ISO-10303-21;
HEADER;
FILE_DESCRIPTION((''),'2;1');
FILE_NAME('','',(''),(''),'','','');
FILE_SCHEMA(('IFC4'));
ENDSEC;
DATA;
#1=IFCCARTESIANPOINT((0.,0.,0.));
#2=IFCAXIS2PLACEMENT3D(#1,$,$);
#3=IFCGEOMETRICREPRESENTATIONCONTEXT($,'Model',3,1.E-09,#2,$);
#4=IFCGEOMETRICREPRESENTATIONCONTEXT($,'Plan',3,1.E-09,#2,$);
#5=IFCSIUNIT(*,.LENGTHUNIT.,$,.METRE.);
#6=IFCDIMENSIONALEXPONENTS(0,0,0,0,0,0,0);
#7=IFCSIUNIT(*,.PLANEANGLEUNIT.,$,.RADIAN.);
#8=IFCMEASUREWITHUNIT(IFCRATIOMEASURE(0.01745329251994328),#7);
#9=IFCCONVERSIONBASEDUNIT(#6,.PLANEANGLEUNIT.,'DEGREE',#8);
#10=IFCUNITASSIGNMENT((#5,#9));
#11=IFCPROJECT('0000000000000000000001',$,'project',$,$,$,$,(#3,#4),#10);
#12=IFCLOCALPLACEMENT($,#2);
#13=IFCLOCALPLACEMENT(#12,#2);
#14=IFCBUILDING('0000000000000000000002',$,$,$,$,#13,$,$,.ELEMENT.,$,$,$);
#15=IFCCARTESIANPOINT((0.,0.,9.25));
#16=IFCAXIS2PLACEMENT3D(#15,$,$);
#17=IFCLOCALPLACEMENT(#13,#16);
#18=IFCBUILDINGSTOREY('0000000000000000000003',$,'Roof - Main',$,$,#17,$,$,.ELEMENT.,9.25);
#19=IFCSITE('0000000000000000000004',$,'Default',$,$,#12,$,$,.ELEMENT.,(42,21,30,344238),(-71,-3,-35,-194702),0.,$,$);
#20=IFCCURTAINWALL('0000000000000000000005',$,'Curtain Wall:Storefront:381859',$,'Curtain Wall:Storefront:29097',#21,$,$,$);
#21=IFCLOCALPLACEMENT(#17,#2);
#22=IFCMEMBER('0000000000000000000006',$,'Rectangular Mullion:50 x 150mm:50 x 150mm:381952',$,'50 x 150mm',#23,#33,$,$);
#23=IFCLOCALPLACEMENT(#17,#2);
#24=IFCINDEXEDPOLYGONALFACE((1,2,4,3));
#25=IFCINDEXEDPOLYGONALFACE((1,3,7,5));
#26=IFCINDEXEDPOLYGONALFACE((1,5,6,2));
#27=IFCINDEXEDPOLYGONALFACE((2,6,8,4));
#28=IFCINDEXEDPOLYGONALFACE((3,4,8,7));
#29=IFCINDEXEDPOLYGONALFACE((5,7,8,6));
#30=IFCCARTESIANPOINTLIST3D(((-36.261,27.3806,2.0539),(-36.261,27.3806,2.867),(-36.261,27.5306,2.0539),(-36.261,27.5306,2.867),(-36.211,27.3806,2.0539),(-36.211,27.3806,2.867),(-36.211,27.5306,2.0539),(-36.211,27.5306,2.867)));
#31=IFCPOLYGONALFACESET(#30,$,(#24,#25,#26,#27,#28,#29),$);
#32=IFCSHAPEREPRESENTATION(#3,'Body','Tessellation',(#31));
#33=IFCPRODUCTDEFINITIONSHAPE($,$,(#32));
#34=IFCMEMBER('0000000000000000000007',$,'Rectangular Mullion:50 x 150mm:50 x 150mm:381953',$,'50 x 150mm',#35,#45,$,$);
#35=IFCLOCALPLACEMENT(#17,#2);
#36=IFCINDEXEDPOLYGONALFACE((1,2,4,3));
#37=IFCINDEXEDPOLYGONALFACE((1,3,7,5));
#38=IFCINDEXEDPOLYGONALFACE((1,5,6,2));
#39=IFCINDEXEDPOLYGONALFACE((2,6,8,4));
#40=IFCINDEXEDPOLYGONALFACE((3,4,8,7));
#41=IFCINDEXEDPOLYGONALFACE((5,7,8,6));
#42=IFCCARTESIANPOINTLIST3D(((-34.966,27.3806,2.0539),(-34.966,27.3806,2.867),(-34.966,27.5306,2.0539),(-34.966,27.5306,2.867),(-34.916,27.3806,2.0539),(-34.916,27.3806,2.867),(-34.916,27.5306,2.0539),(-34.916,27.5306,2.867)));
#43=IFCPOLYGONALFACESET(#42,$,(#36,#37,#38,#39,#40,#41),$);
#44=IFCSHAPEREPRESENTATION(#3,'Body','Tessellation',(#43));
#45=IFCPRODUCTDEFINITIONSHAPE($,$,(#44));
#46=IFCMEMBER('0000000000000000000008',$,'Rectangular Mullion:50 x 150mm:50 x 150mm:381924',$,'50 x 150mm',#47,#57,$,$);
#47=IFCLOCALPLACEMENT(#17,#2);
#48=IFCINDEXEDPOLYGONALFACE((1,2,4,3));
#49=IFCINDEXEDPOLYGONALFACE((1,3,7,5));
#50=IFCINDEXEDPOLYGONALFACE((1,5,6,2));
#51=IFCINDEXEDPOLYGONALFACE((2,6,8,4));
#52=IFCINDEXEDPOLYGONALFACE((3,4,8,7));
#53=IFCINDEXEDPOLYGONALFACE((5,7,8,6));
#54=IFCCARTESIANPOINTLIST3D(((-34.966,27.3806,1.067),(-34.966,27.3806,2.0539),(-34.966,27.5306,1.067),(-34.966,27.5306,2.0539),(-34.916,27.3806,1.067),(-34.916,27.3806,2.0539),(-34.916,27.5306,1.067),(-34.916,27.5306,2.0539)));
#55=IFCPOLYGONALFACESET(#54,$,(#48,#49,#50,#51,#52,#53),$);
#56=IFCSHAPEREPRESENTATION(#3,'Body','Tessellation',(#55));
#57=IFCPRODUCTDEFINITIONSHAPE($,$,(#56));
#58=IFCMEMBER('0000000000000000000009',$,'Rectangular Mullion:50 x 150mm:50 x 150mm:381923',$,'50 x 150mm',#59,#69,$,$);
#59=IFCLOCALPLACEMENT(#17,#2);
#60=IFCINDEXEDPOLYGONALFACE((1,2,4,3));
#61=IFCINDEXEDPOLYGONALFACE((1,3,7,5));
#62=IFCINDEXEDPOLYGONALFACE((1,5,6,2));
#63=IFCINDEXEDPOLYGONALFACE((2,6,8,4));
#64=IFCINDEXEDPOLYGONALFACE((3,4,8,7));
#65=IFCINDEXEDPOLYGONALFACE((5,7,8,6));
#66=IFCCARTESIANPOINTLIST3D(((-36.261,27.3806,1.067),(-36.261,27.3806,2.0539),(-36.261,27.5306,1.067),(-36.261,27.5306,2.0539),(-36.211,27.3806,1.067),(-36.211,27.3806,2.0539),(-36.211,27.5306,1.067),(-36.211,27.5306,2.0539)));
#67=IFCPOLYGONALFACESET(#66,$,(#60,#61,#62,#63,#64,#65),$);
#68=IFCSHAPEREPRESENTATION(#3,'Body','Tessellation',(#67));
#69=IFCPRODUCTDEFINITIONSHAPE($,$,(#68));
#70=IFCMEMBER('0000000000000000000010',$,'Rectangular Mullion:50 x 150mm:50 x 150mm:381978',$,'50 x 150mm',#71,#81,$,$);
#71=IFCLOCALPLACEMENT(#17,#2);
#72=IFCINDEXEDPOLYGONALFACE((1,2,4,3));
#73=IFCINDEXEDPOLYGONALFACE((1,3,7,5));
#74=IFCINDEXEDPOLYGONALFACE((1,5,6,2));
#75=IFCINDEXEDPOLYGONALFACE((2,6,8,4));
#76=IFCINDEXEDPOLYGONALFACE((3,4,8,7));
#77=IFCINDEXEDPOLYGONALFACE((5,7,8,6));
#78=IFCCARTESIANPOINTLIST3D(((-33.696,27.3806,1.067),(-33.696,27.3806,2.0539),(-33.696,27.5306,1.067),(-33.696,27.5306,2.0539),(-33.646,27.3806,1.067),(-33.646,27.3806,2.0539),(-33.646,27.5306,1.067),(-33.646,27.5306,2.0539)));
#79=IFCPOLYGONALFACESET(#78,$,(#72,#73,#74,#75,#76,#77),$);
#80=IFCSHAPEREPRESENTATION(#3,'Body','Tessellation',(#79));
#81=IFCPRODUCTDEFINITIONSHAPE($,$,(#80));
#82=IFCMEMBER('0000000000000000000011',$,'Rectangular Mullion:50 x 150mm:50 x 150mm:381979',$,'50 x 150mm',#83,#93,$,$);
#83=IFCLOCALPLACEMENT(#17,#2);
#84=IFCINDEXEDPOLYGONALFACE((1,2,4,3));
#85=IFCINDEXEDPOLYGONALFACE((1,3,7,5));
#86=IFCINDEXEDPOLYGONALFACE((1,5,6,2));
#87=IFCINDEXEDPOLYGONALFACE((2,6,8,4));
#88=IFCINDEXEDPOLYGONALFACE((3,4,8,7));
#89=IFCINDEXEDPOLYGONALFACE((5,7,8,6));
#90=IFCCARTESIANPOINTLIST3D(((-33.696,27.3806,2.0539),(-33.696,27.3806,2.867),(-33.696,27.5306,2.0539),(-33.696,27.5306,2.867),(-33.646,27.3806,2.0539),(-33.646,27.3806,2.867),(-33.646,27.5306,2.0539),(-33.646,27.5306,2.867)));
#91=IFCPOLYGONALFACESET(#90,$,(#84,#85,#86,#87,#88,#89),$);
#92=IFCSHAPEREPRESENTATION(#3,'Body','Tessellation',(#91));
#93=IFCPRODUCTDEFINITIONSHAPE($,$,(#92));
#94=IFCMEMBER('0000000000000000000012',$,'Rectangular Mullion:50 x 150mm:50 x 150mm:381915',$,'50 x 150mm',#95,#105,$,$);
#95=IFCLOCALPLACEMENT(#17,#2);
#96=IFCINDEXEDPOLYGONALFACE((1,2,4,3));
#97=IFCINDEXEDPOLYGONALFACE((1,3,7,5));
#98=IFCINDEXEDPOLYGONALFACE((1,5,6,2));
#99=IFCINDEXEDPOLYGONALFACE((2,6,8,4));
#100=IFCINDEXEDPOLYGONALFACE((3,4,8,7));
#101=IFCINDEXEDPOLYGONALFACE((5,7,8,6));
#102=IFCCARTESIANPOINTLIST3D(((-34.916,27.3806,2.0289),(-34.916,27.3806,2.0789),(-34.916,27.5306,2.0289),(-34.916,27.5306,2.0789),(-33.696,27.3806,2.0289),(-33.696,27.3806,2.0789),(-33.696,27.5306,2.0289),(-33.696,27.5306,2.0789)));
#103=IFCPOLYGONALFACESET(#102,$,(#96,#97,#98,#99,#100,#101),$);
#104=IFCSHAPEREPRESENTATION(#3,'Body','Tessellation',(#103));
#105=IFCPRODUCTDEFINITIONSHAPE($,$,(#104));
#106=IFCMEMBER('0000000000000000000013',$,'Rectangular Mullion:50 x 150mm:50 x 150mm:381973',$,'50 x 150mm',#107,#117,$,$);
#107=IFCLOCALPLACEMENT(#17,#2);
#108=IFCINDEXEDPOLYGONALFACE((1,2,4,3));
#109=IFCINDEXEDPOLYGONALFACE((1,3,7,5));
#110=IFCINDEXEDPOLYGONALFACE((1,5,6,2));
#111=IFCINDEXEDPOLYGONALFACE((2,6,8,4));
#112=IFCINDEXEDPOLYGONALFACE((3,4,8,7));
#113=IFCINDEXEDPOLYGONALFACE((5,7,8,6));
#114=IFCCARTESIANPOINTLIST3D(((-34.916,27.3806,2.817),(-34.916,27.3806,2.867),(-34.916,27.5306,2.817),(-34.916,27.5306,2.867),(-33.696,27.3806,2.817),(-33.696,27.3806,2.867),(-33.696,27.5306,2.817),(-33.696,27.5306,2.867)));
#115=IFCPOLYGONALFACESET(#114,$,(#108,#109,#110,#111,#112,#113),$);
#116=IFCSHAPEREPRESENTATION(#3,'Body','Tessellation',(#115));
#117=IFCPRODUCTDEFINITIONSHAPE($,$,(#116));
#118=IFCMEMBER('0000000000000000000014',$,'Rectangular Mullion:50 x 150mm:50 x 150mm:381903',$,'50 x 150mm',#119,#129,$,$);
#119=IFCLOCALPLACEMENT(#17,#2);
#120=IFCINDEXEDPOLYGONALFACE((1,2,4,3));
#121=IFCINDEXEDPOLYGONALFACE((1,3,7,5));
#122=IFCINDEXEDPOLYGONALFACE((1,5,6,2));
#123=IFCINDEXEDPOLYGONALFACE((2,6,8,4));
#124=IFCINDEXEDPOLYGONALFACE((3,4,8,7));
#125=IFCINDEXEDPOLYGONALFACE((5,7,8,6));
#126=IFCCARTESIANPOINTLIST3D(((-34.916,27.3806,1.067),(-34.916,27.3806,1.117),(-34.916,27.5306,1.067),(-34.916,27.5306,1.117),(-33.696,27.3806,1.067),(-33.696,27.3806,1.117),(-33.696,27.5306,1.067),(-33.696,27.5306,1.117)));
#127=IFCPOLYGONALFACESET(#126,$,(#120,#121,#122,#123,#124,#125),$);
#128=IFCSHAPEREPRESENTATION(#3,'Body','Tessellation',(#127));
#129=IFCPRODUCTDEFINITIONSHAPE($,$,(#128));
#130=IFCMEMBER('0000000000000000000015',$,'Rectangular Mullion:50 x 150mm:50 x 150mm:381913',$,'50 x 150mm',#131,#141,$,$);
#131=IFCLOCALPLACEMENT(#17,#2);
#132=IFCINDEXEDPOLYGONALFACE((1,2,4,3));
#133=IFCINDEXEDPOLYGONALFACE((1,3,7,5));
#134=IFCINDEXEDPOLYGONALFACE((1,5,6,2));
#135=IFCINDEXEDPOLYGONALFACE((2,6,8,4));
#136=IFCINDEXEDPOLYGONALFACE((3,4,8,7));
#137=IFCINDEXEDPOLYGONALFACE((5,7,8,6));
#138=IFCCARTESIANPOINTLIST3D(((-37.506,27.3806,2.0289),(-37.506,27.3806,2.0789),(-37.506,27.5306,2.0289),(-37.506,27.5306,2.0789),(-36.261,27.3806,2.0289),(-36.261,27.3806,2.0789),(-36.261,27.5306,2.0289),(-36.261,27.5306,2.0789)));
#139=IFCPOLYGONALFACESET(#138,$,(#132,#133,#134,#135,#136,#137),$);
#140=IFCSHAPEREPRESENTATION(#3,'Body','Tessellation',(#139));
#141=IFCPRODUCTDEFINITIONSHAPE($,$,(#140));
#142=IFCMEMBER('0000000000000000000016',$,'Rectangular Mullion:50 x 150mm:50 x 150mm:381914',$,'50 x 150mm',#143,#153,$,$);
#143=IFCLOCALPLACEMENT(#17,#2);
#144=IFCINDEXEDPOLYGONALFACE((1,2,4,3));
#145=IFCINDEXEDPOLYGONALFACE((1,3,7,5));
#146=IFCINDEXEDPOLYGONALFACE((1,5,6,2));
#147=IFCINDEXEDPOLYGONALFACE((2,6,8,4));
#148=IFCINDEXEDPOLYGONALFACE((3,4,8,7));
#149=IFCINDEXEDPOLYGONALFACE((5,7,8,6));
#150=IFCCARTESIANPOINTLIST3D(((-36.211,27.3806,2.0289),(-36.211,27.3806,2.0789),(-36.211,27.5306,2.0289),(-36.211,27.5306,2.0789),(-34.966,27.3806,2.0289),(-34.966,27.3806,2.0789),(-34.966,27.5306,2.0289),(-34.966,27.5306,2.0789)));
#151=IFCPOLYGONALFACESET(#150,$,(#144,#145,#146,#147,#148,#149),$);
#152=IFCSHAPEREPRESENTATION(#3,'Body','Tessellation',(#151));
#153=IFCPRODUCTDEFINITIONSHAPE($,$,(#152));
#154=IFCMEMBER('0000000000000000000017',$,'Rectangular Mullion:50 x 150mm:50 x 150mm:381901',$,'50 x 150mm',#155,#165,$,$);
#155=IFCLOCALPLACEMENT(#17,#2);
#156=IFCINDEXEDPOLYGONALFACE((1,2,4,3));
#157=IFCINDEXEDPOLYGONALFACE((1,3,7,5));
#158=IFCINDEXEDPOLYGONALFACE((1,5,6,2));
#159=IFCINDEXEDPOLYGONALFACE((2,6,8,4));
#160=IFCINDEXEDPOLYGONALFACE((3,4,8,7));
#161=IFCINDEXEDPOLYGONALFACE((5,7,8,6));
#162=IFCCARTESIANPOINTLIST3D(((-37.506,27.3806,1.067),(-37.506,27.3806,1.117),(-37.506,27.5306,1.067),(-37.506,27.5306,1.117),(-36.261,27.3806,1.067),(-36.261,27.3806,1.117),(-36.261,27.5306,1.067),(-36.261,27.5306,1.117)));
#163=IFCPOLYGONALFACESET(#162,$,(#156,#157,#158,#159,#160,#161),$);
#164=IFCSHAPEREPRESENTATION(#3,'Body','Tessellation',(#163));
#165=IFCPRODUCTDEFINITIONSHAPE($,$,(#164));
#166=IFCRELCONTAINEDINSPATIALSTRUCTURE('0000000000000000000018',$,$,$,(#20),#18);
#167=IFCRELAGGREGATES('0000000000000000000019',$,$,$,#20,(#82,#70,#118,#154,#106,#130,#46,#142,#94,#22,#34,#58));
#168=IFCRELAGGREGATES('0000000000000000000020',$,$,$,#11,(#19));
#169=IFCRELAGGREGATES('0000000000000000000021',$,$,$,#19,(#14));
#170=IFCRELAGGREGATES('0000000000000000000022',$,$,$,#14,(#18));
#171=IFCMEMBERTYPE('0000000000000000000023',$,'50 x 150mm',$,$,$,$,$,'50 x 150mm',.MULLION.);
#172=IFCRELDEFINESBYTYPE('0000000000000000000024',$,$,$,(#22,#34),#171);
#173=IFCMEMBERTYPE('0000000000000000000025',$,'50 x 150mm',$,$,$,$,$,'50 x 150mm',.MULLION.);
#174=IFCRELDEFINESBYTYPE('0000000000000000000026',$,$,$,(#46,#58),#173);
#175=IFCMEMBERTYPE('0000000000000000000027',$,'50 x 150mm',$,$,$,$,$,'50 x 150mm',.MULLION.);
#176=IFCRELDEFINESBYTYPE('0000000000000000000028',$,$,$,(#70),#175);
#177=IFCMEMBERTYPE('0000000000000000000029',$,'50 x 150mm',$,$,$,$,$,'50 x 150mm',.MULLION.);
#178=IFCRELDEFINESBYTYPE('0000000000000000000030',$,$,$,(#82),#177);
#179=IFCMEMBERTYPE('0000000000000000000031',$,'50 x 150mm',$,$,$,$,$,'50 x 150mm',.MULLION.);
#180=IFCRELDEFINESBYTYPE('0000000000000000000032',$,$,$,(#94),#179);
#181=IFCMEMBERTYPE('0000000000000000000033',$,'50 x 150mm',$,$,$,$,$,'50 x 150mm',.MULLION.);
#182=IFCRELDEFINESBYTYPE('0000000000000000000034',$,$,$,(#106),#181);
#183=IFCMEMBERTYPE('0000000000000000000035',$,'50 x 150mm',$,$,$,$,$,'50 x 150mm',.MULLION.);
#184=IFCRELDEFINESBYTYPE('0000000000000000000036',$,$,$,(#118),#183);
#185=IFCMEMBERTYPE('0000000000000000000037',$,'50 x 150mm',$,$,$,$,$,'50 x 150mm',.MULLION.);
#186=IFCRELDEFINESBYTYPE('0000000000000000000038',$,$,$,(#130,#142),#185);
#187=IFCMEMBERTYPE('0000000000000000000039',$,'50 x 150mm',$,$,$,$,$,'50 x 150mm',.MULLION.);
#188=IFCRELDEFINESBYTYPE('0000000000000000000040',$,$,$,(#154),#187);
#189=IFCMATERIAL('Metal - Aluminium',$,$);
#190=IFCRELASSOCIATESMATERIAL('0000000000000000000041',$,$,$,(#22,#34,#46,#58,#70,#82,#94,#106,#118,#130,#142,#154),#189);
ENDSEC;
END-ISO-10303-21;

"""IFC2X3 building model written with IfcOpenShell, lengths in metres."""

from ifc_helpers import new_model, entity, si_unit, converted_unit, frame, origin, origin_2d_with_axis, place, context, project, spatial, rectangle, extrude, source, transform, mapped, material, type_object, type_shapes, element, aggregate, save


model = new_model("IFC2X3")

# Units and contexts
model_context = context("Model", 3, precision=1e-09, world=origin())
plan_context = context("Plan", 3, precision=1e-09, world=origin())
ifc_project = project(units=[si_unit("LENGTHUNIT", "METRE"), converted_unit("PLANEANGLEUNIT", "DEGREE", entity("IfcRatioMeasure", 0.01745329251994328), si_unit("PLANEANGLEUNIT", "RADIAN"), dimensions=[0, 0, 0, 0, 0, 0, 0])], contexts=[model_context, plan_context])

# Site, building, storey
site_placement = place(None, origin())
site = spatial("IfcSite", under=ifc_project, at=site_placement, Name="Default", CompositionType="ELEMENT", RefLatitude=(42, 21, 30, 344238), RefLongitude=(-71, -3, -35, -194702), RefElevation=0.0)
building_placement = place(site_placement, origin())
building = spatial("IfcBuilding", under=site, at=building_placement, CompositionType="ELEMENT")
storey_placement = place(building_placement, frame((0.0, 0.0, 9.25)))
storey = spatial("IfcBuildingStorey", under=building, at=storey_placement, Name="Roof - Main", CompositionType="ELEMENT", Elevation=9.25)

# Curtain wall, members
curtain_wall_placement = place(storey_placement, origin())
curtain_wall = element("IfcCurtainWall", 1, at=curtain_wall_placement, inside=storey, Name="Curtain Wall:Storefront:381859", ObjectType="Curtain Wall:Storefront:29097")
ifc_material_1 = material(Name="Metal - Aluminium")
member_type_1 = type_object("IfcMemberType", Name="50 x 150mm", ElementType="50 x 150mm", PredefinedType="MULLION")
shared_shape_1 = source(origin(), model_context, "Body", "SweptSolid", [
    extrude(rectangle(XDim=0.05, YDim=0.15, at=origin_2d_with_axis()), frame((0.0, 0.0, -0.8131), z_axis=(0.0, 0.0, 1.0), x_axis=(-1.0, 0.0, 0.0)), (0.0, 0.0, 1.0), 0.8131),
])
type_shapes(member_type_1, [shared_shape_1])
member_1_placement = place(storey_placement, frame((-36.236, 27.4556, 2.0539), z_axis=(0.0, 0.0, -1.0), x_axis=(1.0, 0.0, 0.0)))
member_1 = element("IfcMember", 2, at=member_1_placement, type_object=member_type_1, material=ifc_material_1, Name="Rectangular Mullion:50 x 150mm:50 x 150mm:381952", ObjectType="50 x 150mm", context=model_context, shape_type="MappedRepresentation", body=[
    mapped(shared_shape_1, transform((0.0, 0.0, 0.0), scale=1.0)),
])
member_2_placement = place(storey_placement, frame((-34.941, 27.4556, 2.0539), z_axis=(0.0, 0.0, -1.0), x_axis=(1.0, 0.0, 0.0)))
member_2 = element("IfcMember", 3, at=member_2_placement, type_object=member_type_1, material=ifc_material_1, Name="Rectangular Mullion:50 x 150mm:50 x 150mm:381953", ObjectType="50 x 150mm", context=model_context, shape_type="MappedRepresentation", body=[
    mapped(shared_shape_1, transform((0.0, 0.0, 0.0), scale=1.0)),
])
member_type_2 = type_object("IfcMemberType", Name="50 x 150mm", ElementType="50 x 150mm", PredefinedType="MULLION")
shared_shape_2 = source(origin(), model_context, "Body", "SweptSolid", [
    extrude(rectangle(XDim=0.05, YDim=0.15, at=origin_2d_with_axis()), frame((0.0, 0.0, -0.9869), z_axis=(0.0, 0.0, 1.0), x_axis=(-1.0, 0.0, 0.0)), (0.0, 0.0, 1.0), 0.9869),
])
type_shapes(member_type_2, [shared_shape_2])
member_3_placement = place(storey_placement, frame((-34.941, 27.4556, 1.067), z_axis=(0.0, 0.0, -1.0), x_axis=(1.0, 0.0, 0.0)))
member_3 = element("IfcMember", 4, at=member_3_placement, type_object=member_type_2, material=ifc_material_1, Name="Rectangular Mullion:50 x 150mm:50 x 150mm:381924", ObjectType="50 x 150mm", context=model_context, shape_type="MappedRepresentation", body=[
    mapped(shared_shape_2, transform((0.0, 0.0, 0.0), scale=1.0)),
])
member_4_placement = place(storey_placement, frame((-36.236, 27.4556, 1.067), z_axis=(0.0, 0.0, -1.0), x_axis=(1.0, 0.0, 0.0)))
member_4 = element("IfcMember", 5, at=member_4_placement, type_object=member_type_2, material=ifc_material_1, Name="Rectangular Mullion:50 x 150mm:50 x 150mm:381923", ObjectType="50 x 150mm", context=model_context, shape_type="MappedRepresentation", body=[
    mapped(shared_shape_2, transform((0.0, 0.0, 0.0), scale=1.0)),
])
member_type_3 = type_object("IfcMemberType", Name="50 x 150mm", ElementType="50 x 150mm", PredefinedType="MULLION")
shared_shape_3 = source(origin(), model_context, "Body", "SweptSolid", [
    extrude(rectangle(XDim=0.05, YDim=0.15, at=origin_2d_with_axis()), frame((-0.025, 0.0, -0.9869), z_axis=(0.0, 0.0, 1.0), x_axis=(-1.0, 0.0, 0.0)), (0.0, 0.0, 1.0), 0.9869),
])
type_shapes(member_type_3, [shared_shape_3])
member_5_placement = place(storey_placement, frame((-33.646, 27.4556, 1.067), z_axis=(0.0, 0.0, -1.0), x_axis=(1.0, 0.0, 0.0)))
member_5 = element("IfcMember", 6, at=member_5_placement, type_object=member_type_3, material=ifc_material_1, Name="Rectangular Mullion:50 x 150mm:50 x 150mm:381978", ObjectType="50 x 150mm", context=model_context, shape_type="MappedRepresentation", body=[
    mapped(shared_shape_3, transform((0.0, 0.0, 0.0), scale=1.0)),
])
member_type_4 = type_object("IfcMemberType", Name="50 x 150mm", ElementType="50 x 150mm", PredefinedType="MULLION")
shared_shape_4 = source(origin(), model_context, "Body", "SweptSolid", [
    extrude(rectangle(XDim=0.05, YDim=0.15, at=origin_2d_with_axis()), frame((-0.025, 0.0, -0.8131), z_axis=(0.0, 0.0, 1.0), x_axis=(-1.0, 0.0, 0.0)), (0.0, 0.0, 1.0), 0.8131),
])
type_shapes(member_type_4, [shared_shape_4])
member_6_placement = place(storey_placement, frame((-33.646, 27.4556, 2.0539), z_axis=(0.0, 0.0, -1.0), x_axis=(1.0, 0.0, 0.0)))
member_6 = element("IfcMember", 7, at=member_6_placement, type_object=member_type_4, material=ifc_material_1, Name="Rectangular Mullion:50 x 150mm:50 x 150mm:381979", ObjectType="50 x 150mm", context=model_context, shape_type="MappedRepresentation", body=[
    mapped(shared_shape_4, transform((0.0, 0.0, 0.0), scale=1.0)),
])
member_type_5 = type_object("IfcMemberType", Name="50 x 150mm", ElementType="50 x 150mm", PredefinedType="MULLION")
shared_shape_5 = source(origin(), model_context, "Body", "SweptSolid", [
    extrude(rectangle(XDim=0.05, YDim=0.15, at=origin_2d_with_axis()), frame((0.0, 0.0, -1.22), z_axis=(0.0, 0.0, 1.0), x_axis=(-1.0, 0.0, 0.0)), (0.0, 0.0, 1.0), 1.22),
])
type_shapes(member_type_5, [shared_shape_5])
member_7_placement = place(storey_placement, frame((-33.696, 27.4556, 2.0539), z_axis=(1.0, 0.0, 0.0), x_axis=(0.0, 0.0, 1.0)))
member_7 = element("IfcMember", 8, at=member_7_placement, type_object=member_type_5, material=ifc_material_1, Name="Rectangular Mullion:50 x 150mm:50 x 150mm:381915", ObjectType="50 x 150mm", context=model_context, shape_type="MappedRepresentation", body=[
    mapped(shared_shape_5, transform((0.0, 0.0, 0.0), scale=1.0)),
])
member_type_6 = type_object("IfcMemberType", Name="50 x 150mm", ElementType="50 x 150mm", PredefinedType="MULLION")
shared_shape_6 = source(origin(), model_context, "Body", "SweptSolid", [
    extrude(rectangle(XDim=0.05, YDim=0.15, at=origin_2d_with_axis()), frame((-0.025, 0.0, -1.22), z_axis=(0.0, 0.0, 1.0), x_axis=(-1.0, 0.0, 0.0)), (0.0, 0.0, 1.0), 1.22),
])
type_shapes(member_type_6, [shared_shape_6])
member_8_placement = place(storey_placement, frame((-33.696, 27.4556, 2.867), z_axis=(1.0, 0.0, 0.0), x_axis=(0.0, 0.0, 1.0)))
member_8 = element("IfcMember", 9, at=member_8_placement, type_object=member_type_6, material=ifc_material_1, Name="Rectangular Mullion:50 x 150mm:50 x 150mm:381973", ObjectType="50 x 150mm", context=model_context, shape_type="MappedRepresentation", body=[
    mapped(shared_shape_6, transform((0.0, 0.0, 0.0), scale=1.0)),
])
member_type_7 = type_object("IfcMemberType", Name="50 x 150mm", ElementType="50 x 150mm", PredefinedType="MULLION")
shared_shape_7 = source(origin(), model_context, "Body", "SweptSolid", [
    extrude(rectangle(XDim=0.05, YDim=0.15, at=origin_2d_with_axis()), frame((-0.025, 0.0, -1.22), z_axis=(0.0, 0.0, 1.0), x_axis=(-1.0, 0.0, 0.0)), (0.0, 0.0, 1.0), 1.22),
])
type_shapes(member_type_7, [shared_shape_7])
member_9_placement = place(storey_placement, frame((-34.916, 27.4556, 1.067), z_axis=(-1.0, 0.0, 0.0), x_axis=(0.0, 0.0, -1.0)))
member_9 = element("IfcMember", 10, at=member_9_placement, type_object=member_type_7, material=ifc_material_1, Name="Rectangular Mullion:50 x 150mm:50 x 150mm:381903", ObjectType="50 x 150mm", context=model_context, shape_type="MappedRepresentation", body=[
    mapped(shared_shape_7, transform((0.0, 0.0, 0.0), scale=1.0)),
])
member_type_8 = type_object("IfcMemberType", Name="50 x 150mm", ElementType="50 x 150mm", PredefinedType="MULLION")
shared_shape_8 = source(origin(), model_context, "Body", "SweptSolid", [
    extrude(rectangle(XDim=0.05, YDim=0.15, at=origin_2d_with_axis()), frame((0.0, 0.0, -1.245), z_axis=(0.0, 0.0, 1.0), x_axis=(-1.0, 0.0, 0.0)), (0.0, 0.0, 1.0), 1.245),
])
type_shapes(member_type_8, [shared_shape_8])
member_10_placement = place(storey_placement, frame((-36.261, 27.4556, 2.0539), z_axis=(1.0, 0.0, 0.0), x_axis=(0.0, 0.0, 1.0)))
member_10 = element("IfcMember", 11, at=member_10_placement, type_object=member_type_8, material=ifc_material_1, Name="Rectangular Mullion:50 x 150mm:50 x 150mm:381913", ObjectType="50 x 150mm", context=model_context, shape_type="MappedRepresentation", body=[
    mapped(shared_shape_8, transform((0.0, 0.0, 0.0), scale=1.0)),
])
member_11_placement = place(storey_placement, frame((-34.966, 27.4556, 2.0539), z_axis=(1.0, 0.0, 0.0), x_axis=(0.0, 0.0, 1.0)))
member_11 = element("IfcMember", 12, at=member_11_placement, type_object=member_type_8, material=ifc_material_1, Name="Rectangular Mullion:50 x 150mm:50 x 150mm:381914", ObjectType="50 x 150mm", context=model_context, shape_type="MappedRepresentation", body=[
    mapped(shared_shape_8, transform((0.0, 0.0, 0.0), scale=1.0)),
])
member_type_9 = type_object("IfcMemberType", Name="50 x 150mm", ElementType="50 x 150mm", PredefinedType="MULLION")
shared_shape_9 = source(origin(), model_context, "Body", "SweptSolid", [
    extrude(rectangle(XDim=0.05, YDim=0.15, at=origin_2d_with_axis()), frame((-0.025, 0.0, -1.245), z_axis=(0.0, 0.0, 1.0), x_axis=(-1.0, 0.0, 0.0)), (0.0, 0.0, 1.0), 1.245),
])
type_shapes(member_type_9, [shared_shape_9])
member_12_placement = place(storey_placement, frame((-37.506, 27.4556, 1.067), z_axis=(-1.0, 0.0, 0.0), x_axis=(0.0, 0.0, -1.0)))
member_12 = element("IfcMember", 13, at=member_12_placement, type_object=member_type_9, material=ifc_material_1, Name="Rectangular Mullion:50 x 150mm:50 x 150mm:381901", ObjectType="50 x 150mm", context=model_context, shape_type="MappedRepresentation", body=[
    mapped(shared_shape_9, transform((0.0, 0.0, 0.0), scale=1.0)),
])
aggregate(curtain_wall, [member_6, member_5, member_9, member_12, member_8, member_10, member_3, member_11, member_7, member_1, member_2, member_4])

save(model, "model.ifc")
